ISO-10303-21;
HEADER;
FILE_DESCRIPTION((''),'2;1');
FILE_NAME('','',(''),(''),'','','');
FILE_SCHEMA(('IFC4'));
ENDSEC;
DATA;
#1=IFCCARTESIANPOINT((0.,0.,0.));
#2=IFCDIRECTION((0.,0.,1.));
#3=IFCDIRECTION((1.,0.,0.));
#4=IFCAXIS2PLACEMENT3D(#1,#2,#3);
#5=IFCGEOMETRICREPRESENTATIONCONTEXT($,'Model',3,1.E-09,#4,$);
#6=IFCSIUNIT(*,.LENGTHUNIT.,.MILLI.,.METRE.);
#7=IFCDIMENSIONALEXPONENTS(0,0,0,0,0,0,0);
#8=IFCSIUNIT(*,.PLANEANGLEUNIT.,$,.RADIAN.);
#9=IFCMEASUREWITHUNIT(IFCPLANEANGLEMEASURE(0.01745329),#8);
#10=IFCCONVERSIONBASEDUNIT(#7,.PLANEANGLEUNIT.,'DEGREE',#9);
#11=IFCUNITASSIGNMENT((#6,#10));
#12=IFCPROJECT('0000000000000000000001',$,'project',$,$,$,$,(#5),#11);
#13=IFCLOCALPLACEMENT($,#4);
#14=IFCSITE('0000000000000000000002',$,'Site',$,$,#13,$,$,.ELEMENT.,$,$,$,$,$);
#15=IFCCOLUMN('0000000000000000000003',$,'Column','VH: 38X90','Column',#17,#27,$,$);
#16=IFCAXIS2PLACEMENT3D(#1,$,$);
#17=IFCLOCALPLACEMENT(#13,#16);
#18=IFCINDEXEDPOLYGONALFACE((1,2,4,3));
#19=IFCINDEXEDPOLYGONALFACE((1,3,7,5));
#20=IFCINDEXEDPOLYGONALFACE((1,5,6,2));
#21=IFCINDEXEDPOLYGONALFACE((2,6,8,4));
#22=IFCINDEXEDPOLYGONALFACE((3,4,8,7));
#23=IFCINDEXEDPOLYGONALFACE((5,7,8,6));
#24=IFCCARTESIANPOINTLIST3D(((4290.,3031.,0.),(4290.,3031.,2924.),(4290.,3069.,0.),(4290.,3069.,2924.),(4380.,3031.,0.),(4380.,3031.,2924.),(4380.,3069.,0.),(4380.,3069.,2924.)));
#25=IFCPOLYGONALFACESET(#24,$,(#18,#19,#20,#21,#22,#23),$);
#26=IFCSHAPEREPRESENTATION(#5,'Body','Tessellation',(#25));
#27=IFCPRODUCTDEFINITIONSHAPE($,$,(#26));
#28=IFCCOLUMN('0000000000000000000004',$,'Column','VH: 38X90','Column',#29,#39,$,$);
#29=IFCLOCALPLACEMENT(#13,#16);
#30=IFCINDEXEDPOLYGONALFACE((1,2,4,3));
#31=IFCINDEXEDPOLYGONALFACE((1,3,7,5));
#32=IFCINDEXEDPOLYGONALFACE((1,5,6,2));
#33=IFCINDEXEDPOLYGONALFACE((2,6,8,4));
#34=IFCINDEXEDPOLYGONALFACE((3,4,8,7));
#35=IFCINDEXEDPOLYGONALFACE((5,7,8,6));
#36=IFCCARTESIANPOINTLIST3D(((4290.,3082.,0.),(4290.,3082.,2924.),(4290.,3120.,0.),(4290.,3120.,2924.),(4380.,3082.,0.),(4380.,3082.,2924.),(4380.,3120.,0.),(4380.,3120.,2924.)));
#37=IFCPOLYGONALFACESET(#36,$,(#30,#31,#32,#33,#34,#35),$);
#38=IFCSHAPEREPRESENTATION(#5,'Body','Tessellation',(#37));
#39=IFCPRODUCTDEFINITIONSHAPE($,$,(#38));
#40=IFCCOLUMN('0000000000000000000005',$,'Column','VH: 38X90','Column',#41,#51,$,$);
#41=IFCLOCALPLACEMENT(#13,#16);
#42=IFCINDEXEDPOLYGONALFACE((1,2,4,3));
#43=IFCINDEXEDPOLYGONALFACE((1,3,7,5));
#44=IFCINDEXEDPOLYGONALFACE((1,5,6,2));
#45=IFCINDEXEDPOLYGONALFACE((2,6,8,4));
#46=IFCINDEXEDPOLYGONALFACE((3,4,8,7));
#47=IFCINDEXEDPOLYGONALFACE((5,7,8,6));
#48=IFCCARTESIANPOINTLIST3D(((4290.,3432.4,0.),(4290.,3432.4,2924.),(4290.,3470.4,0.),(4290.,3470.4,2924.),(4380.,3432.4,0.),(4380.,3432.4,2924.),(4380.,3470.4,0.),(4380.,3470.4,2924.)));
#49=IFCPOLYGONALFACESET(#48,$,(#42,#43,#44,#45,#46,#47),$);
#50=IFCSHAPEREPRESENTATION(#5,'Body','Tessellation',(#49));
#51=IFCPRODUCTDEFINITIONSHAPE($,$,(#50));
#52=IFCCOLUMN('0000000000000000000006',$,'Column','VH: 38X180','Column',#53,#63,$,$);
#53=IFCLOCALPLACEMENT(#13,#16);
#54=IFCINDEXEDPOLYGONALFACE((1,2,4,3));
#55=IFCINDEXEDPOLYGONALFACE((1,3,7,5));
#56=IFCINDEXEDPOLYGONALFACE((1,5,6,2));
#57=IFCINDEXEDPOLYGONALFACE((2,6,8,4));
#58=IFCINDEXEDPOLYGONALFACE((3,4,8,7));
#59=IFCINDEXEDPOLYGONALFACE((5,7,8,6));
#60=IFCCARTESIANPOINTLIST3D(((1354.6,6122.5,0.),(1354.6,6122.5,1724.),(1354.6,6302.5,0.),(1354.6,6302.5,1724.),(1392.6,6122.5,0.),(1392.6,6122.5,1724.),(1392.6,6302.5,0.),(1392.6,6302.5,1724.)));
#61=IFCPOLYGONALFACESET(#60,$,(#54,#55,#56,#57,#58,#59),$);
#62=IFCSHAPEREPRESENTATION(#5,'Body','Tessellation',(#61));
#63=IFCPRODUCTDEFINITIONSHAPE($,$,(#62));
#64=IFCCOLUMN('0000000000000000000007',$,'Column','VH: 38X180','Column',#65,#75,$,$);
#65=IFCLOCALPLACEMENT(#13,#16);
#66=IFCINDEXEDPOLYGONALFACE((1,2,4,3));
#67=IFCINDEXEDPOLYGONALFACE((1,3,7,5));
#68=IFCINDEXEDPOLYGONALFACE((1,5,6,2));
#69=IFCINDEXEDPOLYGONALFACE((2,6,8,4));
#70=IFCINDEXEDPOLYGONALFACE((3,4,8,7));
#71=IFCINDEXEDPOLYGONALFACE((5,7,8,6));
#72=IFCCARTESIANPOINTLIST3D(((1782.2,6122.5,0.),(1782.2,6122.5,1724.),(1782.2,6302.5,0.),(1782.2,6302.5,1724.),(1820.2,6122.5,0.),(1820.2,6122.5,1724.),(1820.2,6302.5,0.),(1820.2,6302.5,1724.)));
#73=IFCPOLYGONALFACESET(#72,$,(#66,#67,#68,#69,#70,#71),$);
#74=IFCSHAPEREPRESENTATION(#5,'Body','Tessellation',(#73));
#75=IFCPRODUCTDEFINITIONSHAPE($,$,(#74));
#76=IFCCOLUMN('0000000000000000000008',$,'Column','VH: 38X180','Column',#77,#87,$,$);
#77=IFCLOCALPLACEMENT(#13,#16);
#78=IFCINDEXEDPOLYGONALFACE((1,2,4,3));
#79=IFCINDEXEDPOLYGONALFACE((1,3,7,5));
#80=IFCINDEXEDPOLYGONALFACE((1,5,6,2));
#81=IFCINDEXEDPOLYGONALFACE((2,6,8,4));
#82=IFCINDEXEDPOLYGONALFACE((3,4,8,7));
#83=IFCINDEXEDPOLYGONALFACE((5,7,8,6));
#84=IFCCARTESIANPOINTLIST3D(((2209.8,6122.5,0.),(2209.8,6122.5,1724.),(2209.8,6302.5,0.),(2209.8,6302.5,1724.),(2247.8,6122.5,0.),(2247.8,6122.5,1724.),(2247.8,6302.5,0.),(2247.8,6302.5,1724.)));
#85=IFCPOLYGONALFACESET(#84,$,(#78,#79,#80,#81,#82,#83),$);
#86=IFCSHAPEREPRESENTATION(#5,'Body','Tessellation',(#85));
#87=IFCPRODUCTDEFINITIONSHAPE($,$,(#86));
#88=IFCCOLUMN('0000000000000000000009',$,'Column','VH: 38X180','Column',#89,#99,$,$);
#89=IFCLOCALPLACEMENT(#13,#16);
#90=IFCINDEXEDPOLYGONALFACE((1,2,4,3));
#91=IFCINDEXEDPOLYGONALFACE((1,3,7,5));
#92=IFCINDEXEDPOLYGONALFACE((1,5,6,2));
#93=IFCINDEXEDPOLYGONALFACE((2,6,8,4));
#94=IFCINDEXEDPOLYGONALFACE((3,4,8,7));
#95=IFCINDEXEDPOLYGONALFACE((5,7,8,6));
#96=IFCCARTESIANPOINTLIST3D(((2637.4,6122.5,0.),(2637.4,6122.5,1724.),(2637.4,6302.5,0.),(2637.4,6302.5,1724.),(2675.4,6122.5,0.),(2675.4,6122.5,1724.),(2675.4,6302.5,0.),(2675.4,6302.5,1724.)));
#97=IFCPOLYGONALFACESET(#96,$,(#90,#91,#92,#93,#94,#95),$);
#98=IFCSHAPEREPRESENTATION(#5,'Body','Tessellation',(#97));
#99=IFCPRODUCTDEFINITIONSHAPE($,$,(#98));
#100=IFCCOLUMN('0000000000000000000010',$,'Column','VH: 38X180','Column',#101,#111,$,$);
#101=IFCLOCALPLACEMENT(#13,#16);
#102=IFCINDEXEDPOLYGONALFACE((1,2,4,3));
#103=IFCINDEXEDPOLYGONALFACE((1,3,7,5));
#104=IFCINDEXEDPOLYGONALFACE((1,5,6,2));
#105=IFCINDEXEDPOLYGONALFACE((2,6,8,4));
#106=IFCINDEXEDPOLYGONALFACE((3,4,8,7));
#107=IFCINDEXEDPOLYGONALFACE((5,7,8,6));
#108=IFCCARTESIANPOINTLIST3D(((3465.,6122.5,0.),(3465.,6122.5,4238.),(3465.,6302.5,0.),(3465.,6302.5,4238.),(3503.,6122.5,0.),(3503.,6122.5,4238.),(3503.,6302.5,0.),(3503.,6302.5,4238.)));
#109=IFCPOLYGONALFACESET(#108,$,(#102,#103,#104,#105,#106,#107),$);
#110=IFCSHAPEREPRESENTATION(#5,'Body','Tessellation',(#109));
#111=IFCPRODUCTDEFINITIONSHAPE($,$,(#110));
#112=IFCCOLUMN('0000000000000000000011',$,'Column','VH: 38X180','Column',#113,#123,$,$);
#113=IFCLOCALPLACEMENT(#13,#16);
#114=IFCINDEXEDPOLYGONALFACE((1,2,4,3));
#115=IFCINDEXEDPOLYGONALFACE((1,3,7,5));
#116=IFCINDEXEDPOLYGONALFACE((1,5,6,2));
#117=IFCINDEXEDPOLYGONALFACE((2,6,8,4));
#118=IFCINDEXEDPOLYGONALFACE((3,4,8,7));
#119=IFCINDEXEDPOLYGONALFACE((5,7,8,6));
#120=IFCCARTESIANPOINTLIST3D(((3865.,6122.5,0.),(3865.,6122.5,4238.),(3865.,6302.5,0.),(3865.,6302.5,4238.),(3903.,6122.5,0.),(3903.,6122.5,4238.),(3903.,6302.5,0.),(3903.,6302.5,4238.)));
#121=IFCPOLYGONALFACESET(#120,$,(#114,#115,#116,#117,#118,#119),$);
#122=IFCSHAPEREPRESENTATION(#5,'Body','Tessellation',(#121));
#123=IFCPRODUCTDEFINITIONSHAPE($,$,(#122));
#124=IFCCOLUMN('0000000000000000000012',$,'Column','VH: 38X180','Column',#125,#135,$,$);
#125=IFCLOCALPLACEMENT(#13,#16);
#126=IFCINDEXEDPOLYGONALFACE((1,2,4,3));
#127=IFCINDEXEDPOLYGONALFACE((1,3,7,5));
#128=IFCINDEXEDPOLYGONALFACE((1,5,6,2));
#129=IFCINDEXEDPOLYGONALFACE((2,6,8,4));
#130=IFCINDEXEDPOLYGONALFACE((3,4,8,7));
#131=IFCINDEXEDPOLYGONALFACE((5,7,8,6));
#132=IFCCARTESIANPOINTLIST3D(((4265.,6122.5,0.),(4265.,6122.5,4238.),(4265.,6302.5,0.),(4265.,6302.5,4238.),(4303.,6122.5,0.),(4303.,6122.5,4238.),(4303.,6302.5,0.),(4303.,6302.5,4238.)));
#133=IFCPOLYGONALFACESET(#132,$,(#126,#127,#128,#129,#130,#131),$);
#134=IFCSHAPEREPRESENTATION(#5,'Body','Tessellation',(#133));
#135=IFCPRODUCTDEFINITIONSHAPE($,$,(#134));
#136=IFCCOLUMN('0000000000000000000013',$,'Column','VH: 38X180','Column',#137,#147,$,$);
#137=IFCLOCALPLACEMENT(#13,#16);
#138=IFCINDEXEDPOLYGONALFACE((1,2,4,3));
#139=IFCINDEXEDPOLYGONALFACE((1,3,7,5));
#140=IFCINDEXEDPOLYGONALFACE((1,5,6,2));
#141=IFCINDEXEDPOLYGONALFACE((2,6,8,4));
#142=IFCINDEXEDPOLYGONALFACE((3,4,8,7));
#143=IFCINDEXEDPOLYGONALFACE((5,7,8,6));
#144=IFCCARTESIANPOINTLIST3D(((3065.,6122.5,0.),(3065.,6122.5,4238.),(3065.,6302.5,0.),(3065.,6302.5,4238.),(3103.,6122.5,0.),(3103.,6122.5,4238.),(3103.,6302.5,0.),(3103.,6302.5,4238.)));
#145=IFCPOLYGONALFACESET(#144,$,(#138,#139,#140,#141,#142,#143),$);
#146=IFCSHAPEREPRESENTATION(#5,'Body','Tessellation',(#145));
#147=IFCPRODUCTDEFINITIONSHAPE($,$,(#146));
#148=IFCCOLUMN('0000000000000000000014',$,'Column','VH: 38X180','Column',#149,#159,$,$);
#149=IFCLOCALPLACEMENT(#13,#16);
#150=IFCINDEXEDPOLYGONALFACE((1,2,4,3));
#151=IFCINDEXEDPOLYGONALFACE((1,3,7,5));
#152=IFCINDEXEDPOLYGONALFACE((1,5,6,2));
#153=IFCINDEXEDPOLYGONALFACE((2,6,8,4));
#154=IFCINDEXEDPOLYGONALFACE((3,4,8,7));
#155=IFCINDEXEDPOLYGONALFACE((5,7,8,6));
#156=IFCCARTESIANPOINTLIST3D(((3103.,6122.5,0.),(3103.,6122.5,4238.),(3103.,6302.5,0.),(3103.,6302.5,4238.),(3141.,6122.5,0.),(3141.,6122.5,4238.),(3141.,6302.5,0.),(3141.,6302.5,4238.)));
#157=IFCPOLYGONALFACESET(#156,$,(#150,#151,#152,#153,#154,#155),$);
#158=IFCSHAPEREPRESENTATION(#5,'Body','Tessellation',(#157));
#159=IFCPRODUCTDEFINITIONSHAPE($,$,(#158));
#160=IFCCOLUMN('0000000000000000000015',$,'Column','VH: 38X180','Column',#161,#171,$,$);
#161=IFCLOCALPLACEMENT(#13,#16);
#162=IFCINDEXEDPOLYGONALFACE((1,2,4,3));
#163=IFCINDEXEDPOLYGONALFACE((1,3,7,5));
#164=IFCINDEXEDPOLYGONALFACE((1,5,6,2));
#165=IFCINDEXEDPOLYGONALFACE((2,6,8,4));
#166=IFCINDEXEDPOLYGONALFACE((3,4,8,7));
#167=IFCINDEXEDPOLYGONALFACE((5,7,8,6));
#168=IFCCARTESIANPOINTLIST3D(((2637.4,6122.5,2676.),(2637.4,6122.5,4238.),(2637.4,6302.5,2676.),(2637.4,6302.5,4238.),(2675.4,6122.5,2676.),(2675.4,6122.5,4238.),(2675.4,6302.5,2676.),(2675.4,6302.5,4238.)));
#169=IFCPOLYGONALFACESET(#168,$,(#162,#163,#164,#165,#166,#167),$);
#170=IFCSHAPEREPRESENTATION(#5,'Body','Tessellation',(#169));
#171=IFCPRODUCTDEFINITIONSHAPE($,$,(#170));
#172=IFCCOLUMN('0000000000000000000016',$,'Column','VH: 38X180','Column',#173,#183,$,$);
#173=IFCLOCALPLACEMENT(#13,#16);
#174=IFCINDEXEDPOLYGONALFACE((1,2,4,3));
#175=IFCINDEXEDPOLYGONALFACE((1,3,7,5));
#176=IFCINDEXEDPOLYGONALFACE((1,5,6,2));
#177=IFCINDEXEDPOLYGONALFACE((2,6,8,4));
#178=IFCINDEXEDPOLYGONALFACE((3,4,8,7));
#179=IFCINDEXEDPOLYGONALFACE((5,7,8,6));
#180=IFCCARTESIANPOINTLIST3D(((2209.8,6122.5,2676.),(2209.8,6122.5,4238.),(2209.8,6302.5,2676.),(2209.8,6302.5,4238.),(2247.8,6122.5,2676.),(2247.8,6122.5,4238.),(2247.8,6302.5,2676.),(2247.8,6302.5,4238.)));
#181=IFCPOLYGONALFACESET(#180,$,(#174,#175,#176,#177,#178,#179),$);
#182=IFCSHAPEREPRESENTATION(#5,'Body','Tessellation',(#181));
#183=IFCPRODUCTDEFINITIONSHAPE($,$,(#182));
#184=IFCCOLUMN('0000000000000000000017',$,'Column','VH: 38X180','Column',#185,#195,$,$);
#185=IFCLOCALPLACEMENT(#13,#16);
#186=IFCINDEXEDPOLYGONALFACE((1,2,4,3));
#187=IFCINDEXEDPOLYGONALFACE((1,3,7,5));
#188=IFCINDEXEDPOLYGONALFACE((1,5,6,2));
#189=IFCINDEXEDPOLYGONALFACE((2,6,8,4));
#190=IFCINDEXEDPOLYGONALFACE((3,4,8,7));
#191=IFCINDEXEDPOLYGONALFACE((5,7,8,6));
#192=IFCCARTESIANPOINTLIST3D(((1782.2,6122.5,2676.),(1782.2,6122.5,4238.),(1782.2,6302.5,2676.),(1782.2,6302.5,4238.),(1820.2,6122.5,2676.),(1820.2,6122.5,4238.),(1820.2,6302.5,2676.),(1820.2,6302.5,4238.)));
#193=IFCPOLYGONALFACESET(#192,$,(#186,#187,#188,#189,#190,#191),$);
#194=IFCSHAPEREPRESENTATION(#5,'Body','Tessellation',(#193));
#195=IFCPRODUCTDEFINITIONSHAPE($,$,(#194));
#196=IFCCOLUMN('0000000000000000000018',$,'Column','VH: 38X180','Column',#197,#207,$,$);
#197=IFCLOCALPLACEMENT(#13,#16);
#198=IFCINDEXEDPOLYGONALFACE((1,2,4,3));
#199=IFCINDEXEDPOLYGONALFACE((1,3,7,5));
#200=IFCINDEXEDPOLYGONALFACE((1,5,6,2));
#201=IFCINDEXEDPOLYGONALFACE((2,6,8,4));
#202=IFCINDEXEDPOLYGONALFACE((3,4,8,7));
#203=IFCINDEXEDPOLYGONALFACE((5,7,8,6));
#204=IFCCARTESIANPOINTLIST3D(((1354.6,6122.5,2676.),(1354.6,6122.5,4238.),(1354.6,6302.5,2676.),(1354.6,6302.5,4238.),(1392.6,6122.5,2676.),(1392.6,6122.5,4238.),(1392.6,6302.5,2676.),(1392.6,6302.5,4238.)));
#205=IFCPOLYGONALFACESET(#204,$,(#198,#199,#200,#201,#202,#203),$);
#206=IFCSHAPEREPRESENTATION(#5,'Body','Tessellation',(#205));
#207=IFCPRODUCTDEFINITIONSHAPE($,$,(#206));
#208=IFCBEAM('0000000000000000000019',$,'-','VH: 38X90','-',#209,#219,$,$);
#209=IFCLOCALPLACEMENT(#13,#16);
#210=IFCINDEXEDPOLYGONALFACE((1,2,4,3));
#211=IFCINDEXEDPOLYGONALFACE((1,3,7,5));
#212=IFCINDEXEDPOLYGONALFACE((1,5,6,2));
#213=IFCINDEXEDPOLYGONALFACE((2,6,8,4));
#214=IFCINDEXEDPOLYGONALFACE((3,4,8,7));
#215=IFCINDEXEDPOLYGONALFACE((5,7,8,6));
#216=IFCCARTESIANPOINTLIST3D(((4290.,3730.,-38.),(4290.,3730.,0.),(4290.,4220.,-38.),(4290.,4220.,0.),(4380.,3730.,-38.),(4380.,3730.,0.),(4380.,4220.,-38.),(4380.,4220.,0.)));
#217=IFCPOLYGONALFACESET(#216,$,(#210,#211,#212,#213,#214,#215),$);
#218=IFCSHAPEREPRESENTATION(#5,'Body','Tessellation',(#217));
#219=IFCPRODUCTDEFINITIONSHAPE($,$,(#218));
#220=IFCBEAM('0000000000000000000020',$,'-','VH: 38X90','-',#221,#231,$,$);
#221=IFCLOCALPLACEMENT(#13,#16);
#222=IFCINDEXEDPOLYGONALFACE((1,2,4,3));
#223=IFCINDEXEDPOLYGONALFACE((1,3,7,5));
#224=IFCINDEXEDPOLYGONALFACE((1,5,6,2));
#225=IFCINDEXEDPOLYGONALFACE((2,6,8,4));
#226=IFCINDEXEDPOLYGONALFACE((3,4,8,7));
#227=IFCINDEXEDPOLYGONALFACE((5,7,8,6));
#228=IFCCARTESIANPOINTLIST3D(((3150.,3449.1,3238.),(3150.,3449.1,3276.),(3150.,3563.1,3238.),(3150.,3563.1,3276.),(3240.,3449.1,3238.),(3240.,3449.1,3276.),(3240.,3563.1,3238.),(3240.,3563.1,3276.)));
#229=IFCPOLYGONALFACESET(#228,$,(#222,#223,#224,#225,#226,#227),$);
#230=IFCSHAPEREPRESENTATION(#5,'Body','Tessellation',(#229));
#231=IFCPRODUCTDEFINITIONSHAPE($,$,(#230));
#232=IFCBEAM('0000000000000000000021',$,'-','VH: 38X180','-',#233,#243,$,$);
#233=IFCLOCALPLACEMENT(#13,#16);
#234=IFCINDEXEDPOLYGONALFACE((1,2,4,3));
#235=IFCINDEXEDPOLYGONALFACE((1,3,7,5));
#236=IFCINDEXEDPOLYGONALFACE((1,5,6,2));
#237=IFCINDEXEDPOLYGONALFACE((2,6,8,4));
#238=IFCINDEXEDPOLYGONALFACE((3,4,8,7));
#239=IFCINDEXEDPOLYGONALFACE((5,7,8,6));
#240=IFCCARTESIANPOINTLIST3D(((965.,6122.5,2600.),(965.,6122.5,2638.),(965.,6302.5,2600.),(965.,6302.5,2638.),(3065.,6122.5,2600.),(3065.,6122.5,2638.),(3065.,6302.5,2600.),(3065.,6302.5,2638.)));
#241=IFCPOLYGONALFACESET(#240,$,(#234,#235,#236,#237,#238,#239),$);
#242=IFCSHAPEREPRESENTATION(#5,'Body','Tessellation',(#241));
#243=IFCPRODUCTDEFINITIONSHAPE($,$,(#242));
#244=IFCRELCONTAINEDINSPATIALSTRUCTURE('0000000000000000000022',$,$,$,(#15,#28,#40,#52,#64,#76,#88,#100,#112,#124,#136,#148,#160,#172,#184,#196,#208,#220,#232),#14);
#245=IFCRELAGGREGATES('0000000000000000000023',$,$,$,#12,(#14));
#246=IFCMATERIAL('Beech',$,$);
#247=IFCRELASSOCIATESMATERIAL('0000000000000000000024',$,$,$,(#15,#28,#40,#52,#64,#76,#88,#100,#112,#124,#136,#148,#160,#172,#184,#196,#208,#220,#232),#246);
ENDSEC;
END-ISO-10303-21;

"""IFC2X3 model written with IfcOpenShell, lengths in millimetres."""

from ifc_helpers import new_model, entity, si_unit, converted_unit, frame, origin, origin_with_axes, origin_2d, place, context, project, spatial, rectangle, extrude, material, element, save


model = new_model("IFC2X3")

# Units and contexts
model_context = context("Model", 3, precision=1e-09, world=origin_with_axes())
ifc_project = project(units=[si_unit("LENGTHUNIT", "METRE", prefix="MILLI"), converted_unit("PLANEANGLEUNIT", "DEGREE", entity("IfcPlaneAngleMeasure", 0.01745329), si_unit("PLANEANGLEUNIT", "RADIAN"), dimensions=[0, 0, 0, 0, 0, 0, 0])], contexts=[model_context])

# Site
site_placement = place(None, origin_with_axes())
site = spatial("IfcSite", under=ifc_project, at=site_placement, Name="Site", CompositionType="ELEMENT")

# Columns
ifc_material_1 = material(Name="Beech")
for number, where, z_axis, x_axis, name in (
    (1, (4335.0, 3050.0, 0.0), (0.0, 0.0, -1.0), (0.0, -1.0, 0.0), "Column"),
    (2, (4335.0, 3101.0, 0.0), (0.0, 0.0, -1.0), (0.0, -1.0, 0.0), "Column"),
    (3, (4335.0, 3451.4, 0.0), (0.0, 0.0, -1.0), (0.0, -1.0, 0.0), "Column"),
):
    element("IfcColumn", number, at=place(None, frame(where, z_axis=z_axis, x_axis=x_axis)), inside=site, material=ifc_material_1, Name=name, Description="VH: 38X90", ObjectType="Column", context=model_context, shape_type="SweptSolid", body=[
        extrude(rectangle(XDim=38.0, YDim=90.0, at=origin_2d()), origin(), (0.0, 0.0, -1.0), 2924.0),
    ])
for number, where, z_axis, x_axis, name in (
    (4, (1373.6, 6212.5, 0.0), (0.0, 0.0, -1.0), (-1.0, 0.0, 0.0), "Column"),
    (5, (1801.2, 6212.5, 0.0), (0.0, 0.0, -1.0), (-1.0, 0.0, 0.0), "Column"),
    (6, (2228.8, 6212.5, 0.0), (0.0, 0.0, -1.0), (-1.0, 0.0, 0.0), "Column"),
    (7, (2656.4, 6212.5, 0.0), (0.0, 0.0, -1.0), (-1.0, 0.0, 0.0), "Column"),
):
    element("IfcColumn", number, at=place(None, frame(where, z_axis=z_axis, x_axis=x_axis)), inside=site, material=ifc_material_1, Name=name, Description="VH: 38X180", ObjectType="Column", context=model_context, shape_type="SweptSolid", body=[
        extrude(rectangle(XDim=38.0, YDim=180.0, at=origin_2d()), origin(), (0.0, 0.0, -1.0), 1724.0),
    ])
for number, where, z_axis, x_axis, name in (
    (8, (3484.0, 6212.5, 0.0), (0.0, 0.0, -1.0), (-1.0, 0.0, 0.0), "Column"),
    (9, (3884.0, 6212.5, 0.0), (0.0, 0.0, -1.0), (-1.0, 0.0, 0.0), "Column"),
    (10, (4284.0, 6212.5, 0.0), (0.0, 0.0, -1.0), (-1.0, 0.0, 0.0), "Column"),
    (11, (3084.0, 6212.5, 0.0), (0.0, 0.0, -1.0), (-1.0, 0.0, 0.0), "Column"),
    (12, (3122.0, 6212.5, 0.0), (0.0, 0.0, -1.0), (-1.0, 0.0, 0.0), "Column"),
):
    element("IfcColumn", number, at=place(None, frame(where, z_axis=z_axis, x_axis=x_axis)), inside=site, material=ifc_material_1, Name=name, Description="VH: 38X180", ObjectType="Column", context=model_context, shape_type="SweptSolid", body=[
        extrude(rectangle(XDim=38.0, YDim=180.0, at=origin_2d()), origin(), (0.0, 0.0, -1.0), 4238.0),
    ])
for number, where, z_axis, x_axis, name in (
    (13, (2656.4, 6212.5, 2676.0), (0.0, 0.0, -1.0), (-1.0, 0.0, 0.0), "Column"),
    (14, (2228.8, 6212.5, 2676.0), (0.0, 0.0, -1.0), (-1.0, 0.0, 0.0), "Column"),
    (15, (1801.2, 6212.5, 2676.0), (0.0, 0.0, -1.0), (-1.0, 0.0, 0.0), "Column"),
    (16, (1373.6, 6212.5, 2676.0), (0.0, 0.0, -1.0), (-1.0, 0.0, 0.0), "Column"),
):
    element("IfcColumn", number, at=place(None, frame(where, z_axis=z_axis, x_axis=x_axis)), inside=site, material=ifc_material_1, Name=name, Description="VH: 38X180", ObjectType="Column", context=model_context, shape_type="SweptSolid", body=[
        extrude(rectangle(XDim=38.0, YDim=180.0, at=origin_2d()), origin(), (0.0, 0.0, -1.0), 1562.0),
    ])

# Beams
beam_1_placement = place(None, frame((4335.0, 3730.0, -19.0), z_axis=(0.0, -1.0, 0.0), x_axis=(0.0, 0.0, -1.0)))
element("IfcBeam", 17, at=beam_1_placement, inside=site, material=ifc_material_1, Name="-", Description="VH: 38X90", ObjectType="-", context=model_context, shape_type="SweptSolid", body=[
    extrude(rectangle(XDim=38.0, YDim=90.0, at=origin_2d()), origin(), (0.0, 0.0, -1.0), 490.0),
])
beam_2_placement = place(None, frame((3195.0, 3563.1, 3257.0), z_axis=(0.0, 1.0, 0.0), x_axis=(0.0, 0.0, -1.0)))
element("IfcBeam", 18, at=beam_2_placement, inside=site, material=ifc_material_1, Name="-", Description="VH: 38X90", ObjectType="-", context=model_context, shape_type="SweptSolid", body=[
    extrude(rectangle(XDim=38.0, YDim=90.0, at=origin_2d()), origin(), (0.0, 0.0, -1.0), 114.0),
])
beam_3_placement = place(None, frame((3065.0, 6212.5, 2619.0), z_axis=(1.0, 0.0, 0.0), x_axis=(0.0, 0.0, -1.0)))
element("IfcBeam", 19, at=beam_3_placement, inside=site, material=ifc_material_1, Name="-", Description="VH: 38X180", ObjectType="-", context=model_context, shape_type="SweptSolid", body=[
    extrude(rectangle(XDim=38.0, YDim=180.0, at=origin_2d()), origin(), (0.0, 0.0, -1.0), 2100.0),
])

save(model, "model.ifc")
